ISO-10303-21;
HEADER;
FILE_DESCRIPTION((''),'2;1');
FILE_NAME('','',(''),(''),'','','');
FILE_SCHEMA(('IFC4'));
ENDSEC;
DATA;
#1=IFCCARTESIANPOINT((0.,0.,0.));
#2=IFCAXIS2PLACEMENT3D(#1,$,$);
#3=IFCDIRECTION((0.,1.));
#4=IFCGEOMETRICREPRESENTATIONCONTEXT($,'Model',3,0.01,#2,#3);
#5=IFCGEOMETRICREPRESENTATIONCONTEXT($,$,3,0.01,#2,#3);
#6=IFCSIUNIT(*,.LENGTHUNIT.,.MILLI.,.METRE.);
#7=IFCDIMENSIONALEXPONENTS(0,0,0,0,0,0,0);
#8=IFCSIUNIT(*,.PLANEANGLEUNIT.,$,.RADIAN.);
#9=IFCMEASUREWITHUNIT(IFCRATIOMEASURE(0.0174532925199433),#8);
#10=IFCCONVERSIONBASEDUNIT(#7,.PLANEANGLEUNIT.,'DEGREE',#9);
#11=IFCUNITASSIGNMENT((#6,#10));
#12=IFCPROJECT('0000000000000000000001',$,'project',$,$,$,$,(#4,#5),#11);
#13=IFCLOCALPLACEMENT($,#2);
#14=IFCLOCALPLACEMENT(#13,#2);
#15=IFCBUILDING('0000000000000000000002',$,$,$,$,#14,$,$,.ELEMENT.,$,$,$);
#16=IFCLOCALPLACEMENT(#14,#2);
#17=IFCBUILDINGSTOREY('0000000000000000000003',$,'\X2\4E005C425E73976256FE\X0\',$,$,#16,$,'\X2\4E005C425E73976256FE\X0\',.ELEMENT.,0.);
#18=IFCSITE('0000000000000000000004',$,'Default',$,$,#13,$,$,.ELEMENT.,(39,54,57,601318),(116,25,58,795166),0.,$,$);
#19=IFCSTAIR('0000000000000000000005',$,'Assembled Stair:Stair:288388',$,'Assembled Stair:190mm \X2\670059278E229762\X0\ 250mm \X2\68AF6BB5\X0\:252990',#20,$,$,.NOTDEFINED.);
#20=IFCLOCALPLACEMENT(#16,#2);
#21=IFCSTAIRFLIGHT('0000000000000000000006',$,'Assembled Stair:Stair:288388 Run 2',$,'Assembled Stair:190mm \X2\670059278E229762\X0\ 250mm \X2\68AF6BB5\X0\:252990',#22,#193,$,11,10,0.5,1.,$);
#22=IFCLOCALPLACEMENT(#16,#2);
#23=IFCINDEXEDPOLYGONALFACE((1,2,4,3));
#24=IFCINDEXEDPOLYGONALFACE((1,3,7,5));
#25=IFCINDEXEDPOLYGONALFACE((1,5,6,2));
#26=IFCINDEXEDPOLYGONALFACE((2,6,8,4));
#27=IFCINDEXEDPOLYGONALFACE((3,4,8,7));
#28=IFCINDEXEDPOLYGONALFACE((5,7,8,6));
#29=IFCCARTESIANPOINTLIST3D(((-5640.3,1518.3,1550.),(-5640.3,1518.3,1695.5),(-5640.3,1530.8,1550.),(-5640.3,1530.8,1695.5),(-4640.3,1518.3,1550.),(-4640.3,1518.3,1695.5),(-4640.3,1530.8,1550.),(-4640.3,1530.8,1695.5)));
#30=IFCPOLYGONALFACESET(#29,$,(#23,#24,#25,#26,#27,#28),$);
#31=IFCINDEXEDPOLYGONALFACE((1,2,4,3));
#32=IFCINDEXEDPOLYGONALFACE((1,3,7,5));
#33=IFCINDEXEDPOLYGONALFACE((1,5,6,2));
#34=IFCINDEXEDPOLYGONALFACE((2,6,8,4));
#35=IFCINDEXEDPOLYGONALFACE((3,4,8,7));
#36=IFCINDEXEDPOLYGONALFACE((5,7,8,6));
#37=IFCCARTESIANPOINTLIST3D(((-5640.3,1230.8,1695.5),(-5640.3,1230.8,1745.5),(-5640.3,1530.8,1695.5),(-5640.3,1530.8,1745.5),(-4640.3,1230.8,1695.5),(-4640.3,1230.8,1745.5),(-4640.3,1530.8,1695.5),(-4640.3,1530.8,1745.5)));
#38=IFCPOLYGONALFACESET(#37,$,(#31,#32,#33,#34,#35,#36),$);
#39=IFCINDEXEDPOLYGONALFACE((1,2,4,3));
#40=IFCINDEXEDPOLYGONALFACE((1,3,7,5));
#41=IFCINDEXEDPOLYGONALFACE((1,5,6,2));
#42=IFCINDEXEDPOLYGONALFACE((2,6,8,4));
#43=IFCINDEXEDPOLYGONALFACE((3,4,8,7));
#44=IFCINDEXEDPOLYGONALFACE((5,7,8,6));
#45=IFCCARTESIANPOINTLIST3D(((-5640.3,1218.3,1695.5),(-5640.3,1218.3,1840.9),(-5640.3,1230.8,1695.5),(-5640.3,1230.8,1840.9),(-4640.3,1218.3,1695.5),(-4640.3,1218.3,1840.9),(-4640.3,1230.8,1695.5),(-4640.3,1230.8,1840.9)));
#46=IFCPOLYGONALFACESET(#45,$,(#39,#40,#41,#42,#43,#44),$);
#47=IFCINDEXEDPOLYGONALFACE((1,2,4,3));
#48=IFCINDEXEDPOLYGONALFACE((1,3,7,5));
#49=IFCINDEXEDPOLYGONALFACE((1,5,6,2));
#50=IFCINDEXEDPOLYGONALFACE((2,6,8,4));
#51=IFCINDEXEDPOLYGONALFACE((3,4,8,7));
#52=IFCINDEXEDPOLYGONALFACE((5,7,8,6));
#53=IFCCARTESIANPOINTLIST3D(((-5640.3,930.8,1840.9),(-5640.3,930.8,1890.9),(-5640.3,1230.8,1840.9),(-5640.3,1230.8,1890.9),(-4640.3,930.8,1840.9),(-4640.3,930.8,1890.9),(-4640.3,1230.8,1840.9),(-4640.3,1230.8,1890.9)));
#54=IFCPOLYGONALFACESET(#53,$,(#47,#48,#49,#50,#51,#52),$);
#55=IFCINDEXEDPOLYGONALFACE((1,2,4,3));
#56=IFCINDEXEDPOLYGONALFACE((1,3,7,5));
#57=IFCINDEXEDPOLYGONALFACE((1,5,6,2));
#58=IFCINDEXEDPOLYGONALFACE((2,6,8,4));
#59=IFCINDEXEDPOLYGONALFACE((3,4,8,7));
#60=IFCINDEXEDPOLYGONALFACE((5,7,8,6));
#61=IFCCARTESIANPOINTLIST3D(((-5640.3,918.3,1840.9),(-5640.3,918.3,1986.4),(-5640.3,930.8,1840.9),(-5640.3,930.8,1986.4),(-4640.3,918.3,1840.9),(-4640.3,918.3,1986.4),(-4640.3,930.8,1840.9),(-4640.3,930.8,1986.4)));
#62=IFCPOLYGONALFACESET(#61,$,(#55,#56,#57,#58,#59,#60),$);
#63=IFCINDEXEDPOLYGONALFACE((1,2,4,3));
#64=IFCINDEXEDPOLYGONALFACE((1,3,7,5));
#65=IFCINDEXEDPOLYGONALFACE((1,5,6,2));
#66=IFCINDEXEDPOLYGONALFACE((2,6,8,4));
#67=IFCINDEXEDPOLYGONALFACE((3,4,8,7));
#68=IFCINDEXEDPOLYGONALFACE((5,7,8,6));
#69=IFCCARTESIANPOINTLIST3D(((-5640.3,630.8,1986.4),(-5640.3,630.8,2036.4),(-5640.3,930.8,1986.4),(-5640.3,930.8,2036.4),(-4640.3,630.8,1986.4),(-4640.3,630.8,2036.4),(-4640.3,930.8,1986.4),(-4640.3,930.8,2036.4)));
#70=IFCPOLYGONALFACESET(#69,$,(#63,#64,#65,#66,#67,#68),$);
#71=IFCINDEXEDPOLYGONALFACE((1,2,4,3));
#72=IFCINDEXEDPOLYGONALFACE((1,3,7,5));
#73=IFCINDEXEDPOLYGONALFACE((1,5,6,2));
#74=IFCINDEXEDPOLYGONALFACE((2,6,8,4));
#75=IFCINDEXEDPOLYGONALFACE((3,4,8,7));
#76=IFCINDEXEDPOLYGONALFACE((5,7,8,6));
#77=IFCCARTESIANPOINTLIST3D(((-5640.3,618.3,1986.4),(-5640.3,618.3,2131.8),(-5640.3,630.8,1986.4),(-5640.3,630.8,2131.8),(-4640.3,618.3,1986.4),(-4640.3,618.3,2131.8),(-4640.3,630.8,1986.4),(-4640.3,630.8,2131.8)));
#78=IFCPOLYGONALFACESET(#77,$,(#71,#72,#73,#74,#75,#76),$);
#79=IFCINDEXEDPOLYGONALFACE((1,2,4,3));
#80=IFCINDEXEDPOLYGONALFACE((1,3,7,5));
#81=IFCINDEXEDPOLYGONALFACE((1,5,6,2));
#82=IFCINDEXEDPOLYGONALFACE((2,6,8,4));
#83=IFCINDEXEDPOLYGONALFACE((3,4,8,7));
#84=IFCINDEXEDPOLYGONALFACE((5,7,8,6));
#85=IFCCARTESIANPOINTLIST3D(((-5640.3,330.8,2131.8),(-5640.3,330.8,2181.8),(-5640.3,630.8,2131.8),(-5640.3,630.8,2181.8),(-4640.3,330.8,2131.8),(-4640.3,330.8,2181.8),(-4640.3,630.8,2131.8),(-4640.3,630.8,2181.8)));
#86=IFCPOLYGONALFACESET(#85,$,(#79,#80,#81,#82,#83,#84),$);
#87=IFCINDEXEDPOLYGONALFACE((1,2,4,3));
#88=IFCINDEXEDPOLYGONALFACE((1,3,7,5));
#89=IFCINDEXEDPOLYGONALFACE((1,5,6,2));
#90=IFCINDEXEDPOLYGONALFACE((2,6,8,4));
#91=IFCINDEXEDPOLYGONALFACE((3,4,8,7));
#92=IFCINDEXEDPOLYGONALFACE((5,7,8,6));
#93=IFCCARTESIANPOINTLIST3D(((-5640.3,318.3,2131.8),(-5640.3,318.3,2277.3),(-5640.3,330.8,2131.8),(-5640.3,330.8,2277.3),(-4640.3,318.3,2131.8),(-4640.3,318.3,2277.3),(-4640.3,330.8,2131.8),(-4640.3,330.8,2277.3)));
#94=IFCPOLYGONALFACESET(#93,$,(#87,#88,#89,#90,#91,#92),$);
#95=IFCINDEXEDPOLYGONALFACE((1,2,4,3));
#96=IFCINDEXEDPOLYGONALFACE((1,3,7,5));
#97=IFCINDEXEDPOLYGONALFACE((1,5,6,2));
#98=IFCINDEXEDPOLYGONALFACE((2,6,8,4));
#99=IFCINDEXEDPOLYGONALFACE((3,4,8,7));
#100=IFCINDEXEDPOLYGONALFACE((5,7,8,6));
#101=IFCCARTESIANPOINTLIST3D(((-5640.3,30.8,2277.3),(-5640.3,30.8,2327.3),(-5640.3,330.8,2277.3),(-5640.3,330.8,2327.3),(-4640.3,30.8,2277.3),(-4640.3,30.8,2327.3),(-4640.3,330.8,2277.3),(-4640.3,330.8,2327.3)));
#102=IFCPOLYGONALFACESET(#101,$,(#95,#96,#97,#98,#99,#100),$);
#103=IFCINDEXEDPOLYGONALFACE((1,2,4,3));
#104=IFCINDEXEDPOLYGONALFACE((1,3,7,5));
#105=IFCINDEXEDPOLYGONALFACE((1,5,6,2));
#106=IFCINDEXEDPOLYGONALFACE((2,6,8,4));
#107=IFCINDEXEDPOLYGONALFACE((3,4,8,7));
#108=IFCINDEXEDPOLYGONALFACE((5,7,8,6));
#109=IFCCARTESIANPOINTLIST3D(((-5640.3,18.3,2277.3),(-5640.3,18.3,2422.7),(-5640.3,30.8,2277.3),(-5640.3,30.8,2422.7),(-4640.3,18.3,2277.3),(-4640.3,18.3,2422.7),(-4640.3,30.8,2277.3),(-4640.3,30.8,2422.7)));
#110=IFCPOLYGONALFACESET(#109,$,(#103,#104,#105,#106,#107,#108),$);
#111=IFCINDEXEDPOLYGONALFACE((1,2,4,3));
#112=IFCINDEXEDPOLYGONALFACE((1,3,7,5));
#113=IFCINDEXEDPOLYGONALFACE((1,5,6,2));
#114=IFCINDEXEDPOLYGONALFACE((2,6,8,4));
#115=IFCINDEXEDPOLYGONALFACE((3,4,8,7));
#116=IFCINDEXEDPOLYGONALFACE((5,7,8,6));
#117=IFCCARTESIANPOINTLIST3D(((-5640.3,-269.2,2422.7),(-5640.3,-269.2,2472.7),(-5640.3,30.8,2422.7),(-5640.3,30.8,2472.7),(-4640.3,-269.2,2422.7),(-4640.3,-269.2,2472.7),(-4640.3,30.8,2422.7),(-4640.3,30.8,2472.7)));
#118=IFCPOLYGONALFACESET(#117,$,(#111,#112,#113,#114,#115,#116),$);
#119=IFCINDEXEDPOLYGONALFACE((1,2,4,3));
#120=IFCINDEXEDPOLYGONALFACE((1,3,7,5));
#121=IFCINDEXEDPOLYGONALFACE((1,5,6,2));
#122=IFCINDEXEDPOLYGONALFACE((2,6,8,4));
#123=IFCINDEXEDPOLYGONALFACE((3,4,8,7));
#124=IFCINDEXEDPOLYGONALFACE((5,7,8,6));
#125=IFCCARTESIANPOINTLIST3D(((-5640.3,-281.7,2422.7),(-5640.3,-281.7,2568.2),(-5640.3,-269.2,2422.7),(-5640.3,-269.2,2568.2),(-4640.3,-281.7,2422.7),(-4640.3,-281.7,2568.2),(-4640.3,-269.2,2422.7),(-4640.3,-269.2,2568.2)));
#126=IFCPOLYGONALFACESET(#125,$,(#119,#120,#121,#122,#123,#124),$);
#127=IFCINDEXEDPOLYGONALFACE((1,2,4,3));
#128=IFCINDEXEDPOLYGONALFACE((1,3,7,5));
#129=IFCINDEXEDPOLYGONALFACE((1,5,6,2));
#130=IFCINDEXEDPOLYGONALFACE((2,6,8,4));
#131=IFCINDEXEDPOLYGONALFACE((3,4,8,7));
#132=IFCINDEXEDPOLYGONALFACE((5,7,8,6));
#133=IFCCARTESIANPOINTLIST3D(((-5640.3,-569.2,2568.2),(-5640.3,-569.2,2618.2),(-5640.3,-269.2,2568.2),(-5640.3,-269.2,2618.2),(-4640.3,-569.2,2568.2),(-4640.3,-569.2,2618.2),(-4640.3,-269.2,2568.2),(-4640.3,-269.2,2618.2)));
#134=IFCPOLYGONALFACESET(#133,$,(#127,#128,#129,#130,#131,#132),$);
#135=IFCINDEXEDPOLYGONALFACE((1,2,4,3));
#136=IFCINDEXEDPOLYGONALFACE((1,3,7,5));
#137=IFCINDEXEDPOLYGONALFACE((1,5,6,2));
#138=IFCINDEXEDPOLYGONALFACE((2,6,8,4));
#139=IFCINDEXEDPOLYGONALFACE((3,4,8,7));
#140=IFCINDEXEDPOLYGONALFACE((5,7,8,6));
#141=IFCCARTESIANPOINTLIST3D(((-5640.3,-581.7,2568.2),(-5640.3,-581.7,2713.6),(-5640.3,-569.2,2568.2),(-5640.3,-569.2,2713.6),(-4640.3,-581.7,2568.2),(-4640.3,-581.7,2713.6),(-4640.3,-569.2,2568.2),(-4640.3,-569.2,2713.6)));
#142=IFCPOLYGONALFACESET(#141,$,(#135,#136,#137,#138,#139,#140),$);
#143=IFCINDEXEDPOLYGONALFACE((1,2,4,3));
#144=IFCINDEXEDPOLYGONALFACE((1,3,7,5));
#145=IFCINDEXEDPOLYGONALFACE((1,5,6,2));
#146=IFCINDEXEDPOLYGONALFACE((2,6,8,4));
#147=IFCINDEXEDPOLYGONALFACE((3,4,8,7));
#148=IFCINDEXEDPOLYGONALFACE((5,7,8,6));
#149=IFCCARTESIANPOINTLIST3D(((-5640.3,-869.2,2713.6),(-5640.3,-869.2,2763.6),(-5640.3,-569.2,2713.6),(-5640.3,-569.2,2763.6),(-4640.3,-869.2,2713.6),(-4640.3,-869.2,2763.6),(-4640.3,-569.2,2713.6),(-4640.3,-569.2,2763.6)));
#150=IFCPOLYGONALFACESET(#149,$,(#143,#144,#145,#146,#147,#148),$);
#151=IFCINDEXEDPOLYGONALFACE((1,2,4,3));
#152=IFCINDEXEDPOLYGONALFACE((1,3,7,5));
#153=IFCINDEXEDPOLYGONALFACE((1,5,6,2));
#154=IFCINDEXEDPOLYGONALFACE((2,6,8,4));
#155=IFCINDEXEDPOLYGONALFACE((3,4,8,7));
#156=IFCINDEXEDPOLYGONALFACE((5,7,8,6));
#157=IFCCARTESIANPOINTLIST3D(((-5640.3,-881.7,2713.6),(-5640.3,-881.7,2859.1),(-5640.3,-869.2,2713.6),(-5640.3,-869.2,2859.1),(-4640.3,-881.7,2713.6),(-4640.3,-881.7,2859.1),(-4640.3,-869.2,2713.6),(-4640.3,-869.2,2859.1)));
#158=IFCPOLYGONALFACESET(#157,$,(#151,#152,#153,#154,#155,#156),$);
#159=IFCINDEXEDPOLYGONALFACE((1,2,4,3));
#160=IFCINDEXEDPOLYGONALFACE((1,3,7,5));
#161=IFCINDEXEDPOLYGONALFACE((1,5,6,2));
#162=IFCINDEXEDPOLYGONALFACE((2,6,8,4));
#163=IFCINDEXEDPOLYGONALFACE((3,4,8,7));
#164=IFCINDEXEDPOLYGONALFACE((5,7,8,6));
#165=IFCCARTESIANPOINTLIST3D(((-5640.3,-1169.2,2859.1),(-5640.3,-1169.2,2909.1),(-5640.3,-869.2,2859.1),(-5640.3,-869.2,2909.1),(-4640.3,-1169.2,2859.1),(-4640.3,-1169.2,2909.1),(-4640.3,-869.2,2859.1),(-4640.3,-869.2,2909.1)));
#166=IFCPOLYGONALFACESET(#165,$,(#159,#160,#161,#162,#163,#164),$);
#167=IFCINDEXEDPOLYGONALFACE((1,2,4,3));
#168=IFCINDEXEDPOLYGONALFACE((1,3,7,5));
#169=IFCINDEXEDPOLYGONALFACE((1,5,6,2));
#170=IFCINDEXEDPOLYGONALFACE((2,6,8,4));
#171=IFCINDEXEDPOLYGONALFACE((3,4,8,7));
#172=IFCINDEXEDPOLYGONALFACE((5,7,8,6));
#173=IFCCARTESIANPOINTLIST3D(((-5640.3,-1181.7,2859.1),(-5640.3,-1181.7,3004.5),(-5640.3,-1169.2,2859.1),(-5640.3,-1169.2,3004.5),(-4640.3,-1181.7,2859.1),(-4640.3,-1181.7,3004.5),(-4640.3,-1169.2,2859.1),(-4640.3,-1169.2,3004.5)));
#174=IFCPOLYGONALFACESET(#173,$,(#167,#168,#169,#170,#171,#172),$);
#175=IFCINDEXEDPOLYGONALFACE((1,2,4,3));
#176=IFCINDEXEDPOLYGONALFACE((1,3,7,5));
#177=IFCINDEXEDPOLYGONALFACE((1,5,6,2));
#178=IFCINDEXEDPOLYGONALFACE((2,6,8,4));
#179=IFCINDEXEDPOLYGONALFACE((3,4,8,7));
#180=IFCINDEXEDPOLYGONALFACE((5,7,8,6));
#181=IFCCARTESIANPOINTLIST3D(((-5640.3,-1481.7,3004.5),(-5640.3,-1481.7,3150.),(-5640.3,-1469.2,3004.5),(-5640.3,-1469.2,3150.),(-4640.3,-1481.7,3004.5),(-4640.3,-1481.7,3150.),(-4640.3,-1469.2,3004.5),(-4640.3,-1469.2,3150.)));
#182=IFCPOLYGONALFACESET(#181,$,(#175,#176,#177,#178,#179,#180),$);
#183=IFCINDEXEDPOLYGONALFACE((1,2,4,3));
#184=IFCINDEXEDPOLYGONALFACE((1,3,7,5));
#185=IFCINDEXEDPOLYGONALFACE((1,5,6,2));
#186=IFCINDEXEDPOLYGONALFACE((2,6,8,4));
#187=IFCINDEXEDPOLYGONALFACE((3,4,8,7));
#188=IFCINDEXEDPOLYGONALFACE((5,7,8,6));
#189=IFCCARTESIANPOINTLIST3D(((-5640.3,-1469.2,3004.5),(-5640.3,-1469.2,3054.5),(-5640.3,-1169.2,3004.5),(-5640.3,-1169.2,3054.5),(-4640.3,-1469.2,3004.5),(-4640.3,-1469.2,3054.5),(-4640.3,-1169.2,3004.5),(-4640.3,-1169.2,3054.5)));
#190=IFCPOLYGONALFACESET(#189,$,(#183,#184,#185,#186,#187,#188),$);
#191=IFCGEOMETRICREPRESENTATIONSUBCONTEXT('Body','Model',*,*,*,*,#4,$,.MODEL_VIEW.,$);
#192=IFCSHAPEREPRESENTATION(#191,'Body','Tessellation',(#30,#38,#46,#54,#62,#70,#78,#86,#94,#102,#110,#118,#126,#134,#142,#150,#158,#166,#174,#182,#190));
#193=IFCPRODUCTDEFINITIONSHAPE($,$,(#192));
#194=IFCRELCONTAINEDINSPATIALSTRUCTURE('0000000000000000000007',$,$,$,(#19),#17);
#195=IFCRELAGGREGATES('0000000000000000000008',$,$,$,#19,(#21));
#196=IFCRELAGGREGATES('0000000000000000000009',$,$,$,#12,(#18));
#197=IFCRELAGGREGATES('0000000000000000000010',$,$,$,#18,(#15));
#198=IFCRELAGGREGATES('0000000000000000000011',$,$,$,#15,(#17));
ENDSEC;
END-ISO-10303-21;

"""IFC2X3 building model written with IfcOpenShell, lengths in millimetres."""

from ifc_helpers import new_model, entity, si_unit, converted_unit, direction, frame, frame_2d, origin, origin_2d_with_axis, place, context, subcontext, project, spatial, rectangle, extrude, element, aggregate, save


model = new_model("IFC2X3")

# Units and contexts
model_context = context("Model", 3, precision=0.01, world=origin(), true_north=direction((0.0, 1.0)))
context_of_model = context(None, 3, precision=0.01, world=origin(), true_north=direction((0.0, 1.0)))
body_context = subcontext(model_context, "Body", "Model", "MODEL_VIEW")
ifc_project = project(units=[si_unit("LENGTHUNIT", "METRE", prefix="MILLI"), converted_unit("PLANEANGLEUNIT", "DEGREE", entity("IfcRatioMeasure", 0.0174532925199433), si_unit("PLANEANGLEUNIT", "RADIAN"), dimensions=[0, 0, 0, 0, 0, 0, 0])], contexts=[model_context, context_of_model])

# Site, building, storey
site_placement = place(None, origin())
site = spatial("IfcSite", under=ifc_project, at=site_placement, Name="Default", CompositionType="ELEMENT", RefLatitude=(39, 54, 57, 601318), RefLongitude=(116, 25, 58, 795166), RefElevation=0.0)
building_placement = place(site_placement, origin())
building = spatial("IfcBuilding", under=site, at=building_placement, CompositionType="ELEMENT")
storey_placement = place(building_placement, origin())
storey = spatial("IfcBuildingStorey", under=building, at=storey_placement, Name="一层平面图", LongName="一层平面图", CompositionType="ELEMENT", Elevation=0.0)

# Stair
stair_placement = place(storey_placement, origin())
stair = element("IfcStair", 1, at=stair_placement, inside=storey, Name="Assembled Stair:Stair:288388", ObjectType="Assembled Stair:190mm 最大踢面 250mm 梯段:252990", ShapeType="NOTDEFINED")

# Stair flight
stair_flight_1_placement = place(stair_placement, origin())
stair_flight_1 = element("IfcStairFlight", 2, at=stair_flight_1_placement, Name="Assembled Stair:Stair:288388 Run 2", ObjectType="Assembled Stair:190mm 最大踢面 250mm 梯段:252990", NumberOfRiser=11, NumberOfTreads=10, RiserHeight=0.5, TreadLength=1.0, context=body_context, shape_type="SweptSolid", body=[
    extrude(rectangle(XDim=1000.0, YDim=12.5, at=origin_2d_with_axis()), frame((-5140.3, 1524.6, 1550.0)), (0.0, 0.0, 1.0), 145.5),
    extrude(rectangle(XDim=300.0, YDim=1000.0, at=frame_2d((0.0, 0.0), x_axis=(1.0, 0.0))), frame((-5140.3, 1380.8, 1695.5), z_axis=(0.0, 0.0, 1.0), x_axis=(0.0, 1.0, 0.0)), (0.0, 0.0, 1.0), 50.0),
    extrude(rectangle(XDim=1000.0, YDim=12.5, at=origin_2d_with_axis()), frame((-5140.3, 1224.6, 1695.5)), (0.0, 0.0, 1.0), 145.5),
    extrude(rectangle(XDim=300.0, YDim=1000.0, at=frame_2d((0.0, 0.0), x_axis=(1.0, 0.0))), frame((-5140.3, 1080.8, 1840.9), z_axis=(0.0, 0.0, 1.0), x_axis=(0.0, 1.0, 0.0)), (0.0, 0.0, 1.0), 50.0),
    extrude(rectangle(XDim=1000.0, YDim=12.5, at=origin_2d_with_axis()), frame((-5140.3, 924.6, 1840.9)), (0.0, 0.0, 1.0), 145.5),
    extrude(rectangle(XDim=300.0, YDim=1000.0, at=frame_2d((0.0, 0.0), x_axis=(1.0, 0.0))), frame((-5140.3, 780.8, 1986.4), z_axis=(0.0, 0.0, 1.0), x_axis=(0.0, 1.0, 0.0)), (0.0, 0.0, 1.0), 50.0),
    extrude(rectangle(XDim=1000.0, YDim=12.5, at=frame_2d((0.0, 0.0), x_axis=(1.0, 0.0))), frame((-5140.3, 624.6, 1986.4)), (0.0, 0.0, 1.0), 145.5),
    extrude(rectangle(XDim=300.0, YDim=1000.0, at=frame_2d((0.0, 0.0), x_axis=(1.0, 0.0))), frame((-5140.3, 480.8, 2131.8), z_axis=(0.0, 0.0, 1.0), x_axis=(0.0, 1.0, 0.0)), (0.0, 0.0, 1.0), 50.0),
    extrude(rectangle(XDim=1000.0, YDim=12.5, at=frame_2d((0.0, 0.0), x_axis=(1.0, 0.0))), frame((-5140.3, 324.6, 2131.8)), (0.0, 0.0, 1.0), 145.5),
    extrude(rectangle(XDim=300.0, YDim=1000.0, at=frame_2d((0.0, 0.0), x_axis=(1.0, 0.0))), frame((-5140.3, 180.8, 2277.3), z_axis=(0.0, 0.0, 1.0), x_axis=(0.0, 1.0, 0.0)), (0.0, 0.0, 1.0), 50.0),
    extrude(rectangle(XDim=1000.0, YDim=12.5, at=frame_2d((0.0, 0.0), x_axis=(1.0, 0.0))), frame((-5140.3, 24.6, 2277.3)), (0.0, 0.0, 1.0), 145.5),
    extrude(rectangle(XDim=300.0, YDim=1000.0, at=frame_2d((0.0, 0.0), x_axis=(1.0, 0.0))), frame((-5140.3, -119.2, 2422.7), z_axis=(0.0, 0.0, 1.0), x_axis=(0.0, 1.0, 0.0)), (0.0, 0.0, 1.0), 50.0),
    extrude(rectangle(XDim=1000.0, YDim=12.5, at=frame_2d((0.0, 0.0), x_axis=(1.0, 0.0))), frame((-5140.3, -275.4, 2422.7)), (0.0, 0.0, 1.0), 145.5),
    extrude(rectangle(XDim=300.0, YDim=1000.0, at=frame_2d((0.0, 0.0), x_axis=(1.0, 0.0))), frame((-5140.3, -419.2, 2568.2), z_axis=(0.0, 0.0, 1.0), x_axis=(0.0, 1.0, 0.0)), (0.0, 0.0, 1.0), 50.0),
    extrude(rectangle(XDim=1000.0, YDim=12.5, at=frame_2d((0.0, 0.0), x_axis=(1.0, 0.0))), frame((-5140.3, -575.4, 2568.2)), (0.0, 0.0, 1.0), 145.5),
    extrude(rectangle(XDim=300.0, YDim=1000.0, at=frame_2d((0.0, 0.0), x_axis=(1.0, 0.0))), frame((-5140.3, -719.2, 2713.6), z_axis=(0.0, 0.0, 1.0), x_axis=(0.0, 1.0, 0.0)), (0.0, 0.0, 1.0), 50.0),
    extrude(rectangle(XDim=1000.0, YDim=12.5, at=frame_2d((0.0, 0.0), x_axis=(1.0, 0.0))), frame((-5140.3, -875.4, 2713.6)), (0.0, 0.0, 1.0), 145.5),
    extrude(rectangle(XDim=300.0, YDim=1000.0, at=frame_2d((0.0, 0.0), x_axis=(1.0, 0.0))), frame((-5140.3, -1019.2, 2859.1), z_axis=(0.0, 0.0, 1.0), x_axis=(0.0, 1.0, 0.0)), (0.0, 0.0, 1.0), 50.0),
    extrude(rectangle(XDim=1000.0, YDim=12.5, at=frame_2d((0.0, 0.0), x_axis=(1.0, 0.0))), frame((-5140.3, -1175.4, 2859.1)), (0.0, 0.0, 1.0), 145.5),
    extrude(rectangle(XDim=1000.0, YDim=12.5, at=origin_2d_with_axis()), frame((-5140.3, -1475.4, 3004.5)), (0.0, 0.0, 1.0), 145.5),
    extrude(rectangle(XDim=300.0, YDim=1000.0, at=frame_2d((0.0, 0.0), x_axis=(1.0, 0.0))), frame((-5140.3, -1319.2, 3004.5), z_axis=(0.0, 0.0, 1.0), x_axis=(0.0, 1.0, 0.0)), (0.0, 0.0, 1.0), 50.0),
])
aggregate(stair, [stair_flight_1])

save(model, "model.ifc")
